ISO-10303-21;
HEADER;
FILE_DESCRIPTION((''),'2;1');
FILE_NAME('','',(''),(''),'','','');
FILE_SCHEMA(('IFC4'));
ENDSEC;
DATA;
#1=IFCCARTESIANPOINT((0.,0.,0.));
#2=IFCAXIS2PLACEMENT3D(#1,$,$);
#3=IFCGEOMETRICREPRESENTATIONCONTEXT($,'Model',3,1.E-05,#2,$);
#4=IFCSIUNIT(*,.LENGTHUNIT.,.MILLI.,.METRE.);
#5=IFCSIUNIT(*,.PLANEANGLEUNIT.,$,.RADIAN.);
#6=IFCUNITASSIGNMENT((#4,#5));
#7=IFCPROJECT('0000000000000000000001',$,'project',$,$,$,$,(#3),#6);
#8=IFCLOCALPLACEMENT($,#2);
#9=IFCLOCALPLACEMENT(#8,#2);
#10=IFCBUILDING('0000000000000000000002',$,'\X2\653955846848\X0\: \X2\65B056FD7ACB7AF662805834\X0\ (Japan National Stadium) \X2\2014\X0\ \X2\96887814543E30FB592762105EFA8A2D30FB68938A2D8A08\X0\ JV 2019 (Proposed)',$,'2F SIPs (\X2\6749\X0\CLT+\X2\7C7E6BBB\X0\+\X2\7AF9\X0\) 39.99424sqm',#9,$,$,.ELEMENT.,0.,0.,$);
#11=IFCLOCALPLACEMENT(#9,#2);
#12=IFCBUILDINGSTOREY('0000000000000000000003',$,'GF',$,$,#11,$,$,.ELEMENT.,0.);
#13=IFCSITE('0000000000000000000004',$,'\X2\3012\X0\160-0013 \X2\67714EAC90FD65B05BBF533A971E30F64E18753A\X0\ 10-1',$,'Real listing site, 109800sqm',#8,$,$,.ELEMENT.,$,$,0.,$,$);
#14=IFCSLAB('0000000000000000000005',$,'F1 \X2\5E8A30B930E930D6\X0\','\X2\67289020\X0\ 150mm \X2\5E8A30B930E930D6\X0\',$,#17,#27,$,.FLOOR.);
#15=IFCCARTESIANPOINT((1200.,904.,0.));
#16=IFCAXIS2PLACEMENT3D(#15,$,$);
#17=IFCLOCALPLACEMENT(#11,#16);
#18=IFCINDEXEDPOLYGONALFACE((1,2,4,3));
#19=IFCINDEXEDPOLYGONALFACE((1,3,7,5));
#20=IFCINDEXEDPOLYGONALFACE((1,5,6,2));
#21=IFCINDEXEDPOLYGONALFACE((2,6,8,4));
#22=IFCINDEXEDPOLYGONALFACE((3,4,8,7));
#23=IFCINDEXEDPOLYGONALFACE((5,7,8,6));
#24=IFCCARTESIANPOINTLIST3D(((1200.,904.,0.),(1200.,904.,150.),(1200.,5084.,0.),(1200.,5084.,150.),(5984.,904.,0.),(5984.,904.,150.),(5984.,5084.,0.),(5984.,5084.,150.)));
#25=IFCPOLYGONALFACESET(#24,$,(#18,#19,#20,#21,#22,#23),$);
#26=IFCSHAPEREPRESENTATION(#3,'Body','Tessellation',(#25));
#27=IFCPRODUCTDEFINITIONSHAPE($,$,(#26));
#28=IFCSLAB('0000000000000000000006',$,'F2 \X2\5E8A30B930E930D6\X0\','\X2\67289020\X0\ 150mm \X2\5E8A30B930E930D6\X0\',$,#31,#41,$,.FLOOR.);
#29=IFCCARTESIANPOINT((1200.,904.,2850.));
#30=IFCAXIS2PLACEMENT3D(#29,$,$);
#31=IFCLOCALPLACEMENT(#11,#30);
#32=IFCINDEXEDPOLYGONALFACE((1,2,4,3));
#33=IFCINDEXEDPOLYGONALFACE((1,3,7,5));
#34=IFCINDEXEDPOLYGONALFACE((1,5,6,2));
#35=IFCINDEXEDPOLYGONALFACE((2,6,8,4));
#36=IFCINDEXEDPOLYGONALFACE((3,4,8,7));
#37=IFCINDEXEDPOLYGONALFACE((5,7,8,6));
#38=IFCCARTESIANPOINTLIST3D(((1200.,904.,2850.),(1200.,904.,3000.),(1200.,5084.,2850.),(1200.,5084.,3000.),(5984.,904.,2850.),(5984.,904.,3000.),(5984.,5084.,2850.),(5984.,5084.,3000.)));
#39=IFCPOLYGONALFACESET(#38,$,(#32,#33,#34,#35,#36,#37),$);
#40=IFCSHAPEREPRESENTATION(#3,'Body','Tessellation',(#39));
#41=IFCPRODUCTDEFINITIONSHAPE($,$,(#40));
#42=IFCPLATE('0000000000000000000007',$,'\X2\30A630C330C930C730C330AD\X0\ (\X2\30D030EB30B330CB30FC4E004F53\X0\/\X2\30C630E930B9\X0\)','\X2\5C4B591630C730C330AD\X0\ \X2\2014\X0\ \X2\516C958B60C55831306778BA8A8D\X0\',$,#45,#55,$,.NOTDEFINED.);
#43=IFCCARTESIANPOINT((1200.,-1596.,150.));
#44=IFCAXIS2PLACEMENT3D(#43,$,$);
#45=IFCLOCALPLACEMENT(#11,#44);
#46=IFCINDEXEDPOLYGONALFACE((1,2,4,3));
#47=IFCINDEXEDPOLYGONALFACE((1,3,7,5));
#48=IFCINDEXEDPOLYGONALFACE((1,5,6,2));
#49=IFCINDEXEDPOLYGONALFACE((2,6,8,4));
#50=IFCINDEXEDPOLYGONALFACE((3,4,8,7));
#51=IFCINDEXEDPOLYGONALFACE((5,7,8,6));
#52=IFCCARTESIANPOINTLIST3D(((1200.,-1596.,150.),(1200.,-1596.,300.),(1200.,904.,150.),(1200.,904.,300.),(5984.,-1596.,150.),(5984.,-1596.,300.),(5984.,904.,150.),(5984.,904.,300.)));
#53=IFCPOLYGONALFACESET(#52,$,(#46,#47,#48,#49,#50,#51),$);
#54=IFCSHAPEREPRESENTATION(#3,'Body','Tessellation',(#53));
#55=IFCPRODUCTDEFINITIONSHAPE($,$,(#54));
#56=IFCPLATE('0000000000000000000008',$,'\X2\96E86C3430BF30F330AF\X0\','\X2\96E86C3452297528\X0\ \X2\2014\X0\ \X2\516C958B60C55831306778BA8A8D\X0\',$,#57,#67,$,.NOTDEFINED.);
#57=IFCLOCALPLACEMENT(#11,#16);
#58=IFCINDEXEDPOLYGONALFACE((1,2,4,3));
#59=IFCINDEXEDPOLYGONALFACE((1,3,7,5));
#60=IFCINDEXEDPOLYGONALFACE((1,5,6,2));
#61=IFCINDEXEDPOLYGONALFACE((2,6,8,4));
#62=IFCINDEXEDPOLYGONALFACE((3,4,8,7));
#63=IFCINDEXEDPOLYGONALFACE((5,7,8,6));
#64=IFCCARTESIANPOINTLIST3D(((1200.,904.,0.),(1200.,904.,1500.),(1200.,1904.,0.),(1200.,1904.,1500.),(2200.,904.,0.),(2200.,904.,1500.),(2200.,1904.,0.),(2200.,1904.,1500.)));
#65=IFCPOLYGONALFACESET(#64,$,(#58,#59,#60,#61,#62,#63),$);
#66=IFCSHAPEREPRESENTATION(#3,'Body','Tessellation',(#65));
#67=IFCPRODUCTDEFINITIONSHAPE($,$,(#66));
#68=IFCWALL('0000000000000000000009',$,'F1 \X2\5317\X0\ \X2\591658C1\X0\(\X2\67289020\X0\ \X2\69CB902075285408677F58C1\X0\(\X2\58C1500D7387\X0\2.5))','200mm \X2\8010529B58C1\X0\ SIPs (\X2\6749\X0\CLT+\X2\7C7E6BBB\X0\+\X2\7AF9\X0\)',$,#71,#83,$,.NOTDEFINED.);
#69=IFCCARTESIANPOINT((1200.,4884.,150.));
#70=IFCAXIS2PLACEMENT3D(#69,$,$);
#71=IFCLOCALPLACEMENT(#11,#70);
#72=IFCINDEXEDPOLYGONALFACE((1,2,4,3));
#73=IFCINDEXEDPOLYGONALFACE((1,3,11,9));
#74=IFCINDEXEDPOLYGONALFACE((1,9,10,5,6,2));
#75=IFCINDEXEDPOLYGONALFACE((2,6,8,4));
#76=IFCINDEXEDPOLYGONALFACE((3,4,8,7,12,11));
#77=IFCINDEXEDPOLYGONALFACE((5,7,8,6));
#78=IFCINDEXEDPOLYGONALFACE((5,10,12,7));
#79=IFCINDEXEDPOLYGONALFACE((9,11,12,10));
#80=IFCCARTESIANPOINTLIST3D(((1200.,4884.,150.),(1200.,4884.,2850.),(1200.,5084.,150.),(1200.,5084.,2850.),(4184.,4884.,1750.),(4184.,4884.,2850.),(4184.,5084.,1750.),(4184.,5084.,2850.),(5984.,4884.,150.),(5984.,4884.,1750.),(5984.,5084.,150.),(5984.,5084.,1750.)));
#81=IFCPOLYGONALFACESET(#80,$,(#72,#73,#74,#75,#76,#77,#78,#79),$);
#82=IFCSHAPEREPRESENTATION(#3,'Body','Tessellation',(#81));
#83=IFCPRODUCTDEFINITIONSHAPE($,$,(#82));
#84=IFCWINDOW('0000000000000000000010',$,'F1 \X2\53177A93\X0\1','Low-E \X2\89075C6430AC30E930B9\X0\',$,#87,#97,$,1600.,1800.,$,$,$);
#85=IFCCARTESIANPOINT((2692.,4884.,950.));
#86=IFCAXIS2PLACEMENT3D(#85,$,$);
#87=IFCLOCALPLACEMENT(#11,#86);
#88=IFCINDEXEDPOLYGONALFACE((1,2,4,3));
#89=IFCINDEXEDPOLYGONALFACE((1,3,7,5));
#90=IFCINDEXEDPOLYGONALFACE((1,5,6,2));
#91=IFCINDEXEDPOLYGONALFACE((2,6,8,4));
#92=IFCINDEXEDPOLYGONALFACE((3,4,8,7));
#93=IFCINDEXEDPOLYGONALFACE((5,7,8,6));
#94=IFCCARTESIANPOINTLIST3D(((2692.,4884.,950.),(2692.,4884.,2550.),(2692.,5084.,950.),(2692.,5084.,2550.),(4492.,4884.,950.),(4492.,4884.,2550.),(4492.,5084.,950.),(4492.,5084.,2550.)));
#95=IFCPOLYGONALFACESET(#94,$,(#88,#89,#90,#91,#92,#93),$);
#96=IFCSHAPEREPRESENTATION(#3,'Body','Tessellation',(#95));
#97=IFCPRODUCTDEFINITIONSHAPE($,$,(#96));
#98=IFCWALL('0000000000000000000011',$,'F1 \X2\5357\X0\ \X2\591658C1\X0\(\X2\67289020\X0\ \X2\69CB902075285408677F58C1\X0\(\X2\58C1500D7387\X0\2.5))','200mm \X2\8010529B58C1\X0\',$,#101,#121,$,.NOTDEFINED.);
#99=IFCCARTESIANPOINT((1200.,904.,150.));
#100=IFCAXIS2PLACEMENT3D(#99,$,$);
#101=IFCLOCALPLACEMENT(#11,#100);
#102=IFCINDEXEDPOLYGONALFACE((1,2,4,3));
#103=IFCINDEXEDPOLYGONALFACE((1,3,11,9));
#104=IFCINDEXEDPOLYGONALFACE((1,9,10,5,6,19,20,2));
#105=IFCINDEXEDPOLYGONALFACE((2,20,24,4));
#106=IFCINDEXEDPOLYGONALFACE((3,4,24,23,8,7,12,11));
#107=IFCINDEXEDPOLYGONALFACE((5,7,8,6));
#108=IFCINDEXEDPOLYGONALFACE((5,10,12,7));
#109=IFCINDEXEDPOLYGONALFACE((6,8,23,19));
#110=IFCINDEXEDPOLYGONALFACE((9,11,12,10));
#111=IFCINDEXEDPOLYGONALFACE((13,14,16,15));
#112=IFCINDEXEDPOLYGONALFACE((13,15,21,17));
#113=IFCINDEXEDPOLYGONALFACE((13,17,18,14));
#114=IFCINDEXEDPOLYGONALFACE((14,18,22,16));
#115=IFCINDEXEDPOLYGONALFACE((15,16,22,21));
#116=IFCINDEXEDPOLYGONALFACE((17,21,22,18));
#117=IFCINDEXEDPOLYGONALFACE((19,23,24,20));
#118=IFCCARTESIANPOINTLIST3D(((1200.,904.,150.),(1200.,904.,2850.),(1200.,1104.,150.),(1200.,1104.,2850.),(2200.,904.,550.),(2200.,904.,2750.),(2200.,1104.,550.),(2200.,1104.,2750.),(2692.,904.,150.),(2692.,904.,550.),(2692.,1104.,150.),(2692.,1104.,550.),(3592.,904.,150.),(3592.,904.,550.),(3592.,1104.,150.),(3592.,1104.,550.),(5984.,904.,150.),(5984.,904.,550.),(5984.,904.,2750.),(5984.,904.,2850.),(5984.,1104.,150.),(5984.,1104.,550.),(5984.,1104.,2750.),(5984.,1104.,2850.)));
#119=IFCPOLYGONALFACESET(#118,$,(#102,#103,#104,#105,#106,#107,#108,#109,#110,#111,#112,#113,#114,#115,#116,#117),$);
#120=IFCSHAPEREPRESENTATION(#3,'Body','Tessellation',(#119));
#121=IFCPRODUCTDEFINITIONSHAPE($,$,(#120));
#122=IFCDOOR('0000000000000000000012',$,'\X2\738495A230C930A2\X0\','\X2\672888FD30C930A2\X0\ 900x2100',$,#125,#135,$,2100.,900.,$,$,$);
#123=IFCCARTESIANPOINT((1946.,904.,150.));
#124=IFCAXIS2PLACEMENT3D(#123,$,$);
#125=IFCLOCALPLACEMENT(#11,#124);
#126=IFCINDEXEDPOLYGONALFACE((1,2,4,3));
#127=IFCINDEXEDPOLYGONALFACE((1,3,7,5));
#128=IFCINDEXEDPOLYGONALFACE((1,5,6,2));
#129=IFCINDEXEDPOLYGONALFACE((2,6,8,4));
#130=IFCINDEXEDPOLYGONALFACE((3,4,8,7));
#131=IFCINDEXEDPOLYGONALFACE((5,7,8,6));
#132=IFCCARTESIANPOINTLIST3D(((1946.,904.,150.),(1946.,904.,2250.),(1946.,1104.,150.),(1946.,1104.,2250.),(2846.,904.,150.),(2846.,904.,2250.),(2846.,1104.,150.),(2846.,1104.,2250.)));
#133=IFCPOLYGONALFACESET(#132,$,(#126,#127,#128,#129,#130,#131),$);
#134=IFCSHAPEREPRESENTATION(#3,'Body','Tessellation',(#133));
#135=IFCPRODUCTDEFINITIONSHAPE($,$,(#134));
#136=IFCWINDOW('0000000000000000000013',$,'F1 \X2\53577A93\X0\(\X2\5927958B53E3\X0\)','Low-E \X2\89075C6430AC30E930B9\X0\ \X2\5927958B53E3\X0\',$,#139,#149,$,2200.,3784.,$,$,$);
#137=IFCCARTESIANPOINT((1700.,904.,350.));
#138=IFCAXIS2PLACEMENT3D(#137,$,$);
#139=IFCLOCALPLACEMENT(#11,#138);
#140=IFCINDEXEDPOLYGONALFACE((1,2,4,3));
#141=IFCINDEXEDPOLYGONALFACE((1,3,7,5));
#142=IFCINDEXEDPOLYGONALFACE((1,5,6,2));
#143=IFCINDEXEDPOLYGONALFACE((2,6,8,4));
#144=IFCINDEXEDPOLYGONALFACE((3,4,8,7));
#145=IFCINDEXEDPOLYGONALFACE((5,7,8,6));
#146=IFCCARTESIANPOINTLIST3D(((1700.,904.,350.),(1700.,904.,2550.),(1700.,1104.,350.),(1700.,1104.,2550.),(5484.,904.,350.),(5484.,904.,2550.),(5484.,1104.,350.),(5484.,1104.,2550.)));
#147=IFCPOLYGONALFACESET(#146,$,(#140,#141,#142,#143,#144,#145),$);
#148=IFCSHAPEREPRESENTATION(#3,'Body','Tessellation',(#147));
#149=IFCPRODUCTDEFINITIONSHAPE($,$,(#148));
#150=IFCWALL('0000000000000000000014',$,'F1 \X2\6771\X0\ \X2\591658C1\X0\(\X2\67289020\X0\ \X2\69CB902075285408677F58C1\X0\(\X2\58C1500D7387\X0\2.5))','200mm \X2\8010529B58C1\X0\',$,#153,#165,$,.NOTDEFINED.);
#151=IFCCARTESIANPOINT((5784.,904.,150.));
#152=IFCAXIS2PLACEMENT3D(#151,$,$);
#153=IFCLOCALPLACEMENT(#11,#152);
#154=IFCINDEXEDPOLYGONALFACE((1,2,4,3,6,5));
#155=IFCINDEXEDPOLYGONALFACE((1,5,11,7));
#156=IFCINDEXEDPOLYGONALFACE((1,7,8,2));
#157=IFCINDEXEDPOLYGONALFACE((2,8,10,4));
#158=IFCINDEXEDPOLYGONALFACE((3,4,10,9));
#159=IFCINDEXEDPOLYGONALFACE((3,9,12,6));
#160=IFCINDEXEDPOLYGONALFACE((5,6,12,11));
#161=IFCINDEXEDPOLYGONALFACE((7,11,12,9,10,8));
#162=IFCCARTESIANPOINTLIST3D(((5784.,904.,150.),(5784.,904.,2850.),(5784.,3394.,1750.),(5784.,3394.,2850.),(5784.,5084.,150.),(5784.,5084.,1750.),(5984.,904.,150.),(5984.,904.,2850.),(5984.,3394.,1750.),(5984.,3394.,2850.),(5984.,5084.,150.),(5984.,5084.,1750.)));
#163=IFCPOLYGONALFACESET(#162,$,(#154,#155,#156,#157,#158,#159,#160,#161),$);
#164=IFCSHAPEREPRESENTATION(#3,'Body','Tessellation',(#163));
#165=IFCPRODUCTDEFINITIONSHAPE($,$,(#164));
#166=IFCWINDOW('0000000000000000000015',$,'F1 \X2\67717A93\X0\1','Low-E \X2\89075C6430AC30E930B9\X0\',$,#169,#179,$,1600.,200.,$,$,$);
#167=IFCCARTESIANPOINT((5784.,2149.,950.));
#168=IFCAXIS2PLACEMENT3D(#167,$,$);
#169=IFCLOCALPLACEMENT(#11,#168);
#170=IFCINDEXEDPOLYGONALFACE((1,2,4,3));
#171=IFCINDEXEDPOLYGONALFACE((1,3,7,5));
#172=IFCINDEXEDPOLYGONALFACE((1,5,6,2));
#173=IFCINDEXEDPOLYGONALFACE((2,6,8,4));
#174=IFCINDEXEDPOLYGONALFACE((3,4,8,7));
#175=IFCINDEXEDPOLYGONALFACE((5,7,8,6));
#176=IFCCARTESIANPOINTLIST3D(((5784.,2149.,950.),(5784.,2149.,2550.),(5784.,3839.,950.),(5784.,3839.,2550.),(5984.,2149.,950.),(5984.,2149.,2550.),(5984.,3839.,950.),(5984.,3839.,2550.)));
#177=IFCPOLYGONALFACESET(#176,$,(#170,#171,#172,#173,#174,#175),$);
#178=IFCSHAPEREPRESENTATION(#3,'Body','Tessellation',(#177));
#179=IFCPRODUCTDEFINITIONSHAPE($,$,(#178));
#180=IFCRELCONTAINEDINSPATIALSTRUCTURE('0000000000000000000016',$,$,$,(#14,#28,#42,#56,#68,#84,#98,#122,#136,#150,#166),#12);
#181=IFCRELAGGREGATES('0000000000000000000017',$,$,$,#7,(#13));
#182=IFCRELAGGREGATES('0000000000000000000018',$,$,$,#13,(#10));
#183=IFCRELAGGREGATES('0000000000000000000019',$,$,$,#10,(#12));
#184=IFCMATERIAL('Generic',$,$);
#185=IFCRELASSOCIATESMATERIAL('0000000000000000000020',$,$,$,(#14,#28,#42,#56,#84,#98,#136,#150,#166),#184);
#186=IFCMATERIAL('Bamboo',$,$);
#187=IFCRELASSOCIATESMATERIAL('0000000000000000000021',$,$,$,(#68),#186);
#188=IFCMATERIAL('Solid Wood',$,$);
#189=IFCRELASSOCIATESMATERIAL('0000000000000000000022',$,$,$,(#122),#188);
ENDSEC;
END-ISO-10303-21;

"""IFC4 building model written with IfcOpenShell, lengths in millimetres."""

from ifc_helpers import new_model, si_unit, frame, frame_2d, origin, place, context, project, spatial, rectangle, extrude, material, element, fill, save


model = new_model("IFC4")

# Units and contexts
model_context = context("Model", 3, precision=1e-05, world=origin())
ifc_project = project(units=[si_unit("LENGTHUNIT", "METRE", prefix="MILLI"), si_unit("PLANEANGLEUNIT", "RADIAN")], contexts=[model_context])

# Site, building, storey
site_placement = place(None, origin())
site = spatial("IfcSite", under=ifc_project, at=site_placement, Name="〒160-0013 東京都新宿区霞ヶ丘町 10-1", ObjectType="Real listing site, 109800sqm", CompositionType="ELEMENT", RefElevation=0.0)
building_placement = place(site_placement, origin())
building = spatial("IfcBuilding", under=site, at=building_placement, Name="改善案: 新国立競技場 (Japan National Stadium) — 隈研吾・大成建設・梓設計 JV 2019 (Proposed)", ObjectType="2F SIPs (杉CLT+籾殻+竹) 39.99424sqm", CompositionType="ELEMENT", ElevationOfRefHeight=0.0, ElevationOfTerrain=0.0)
storey_placement = place(building_placement, origin())
storey = spatial("IfcBuildingStorey", under=building, at=storey_placement, Name="GF", CompositionType="ELEMENT", Elevation=0.0)

# Slabs
ifc_material_1 = material(Name="Generic")
slab_1_placement = place(storey_placement, frame((1200.0, 904.0, 0.0)))
element("IfcSlab", 1, at=slab_1_placement, inside=storey, material=ifc_material_1, Name="F1 床スラブ", Description="木造 150mm 床スラブ", PredefinedType="FLOOR", context=model_context, shape_type="SweptSolid", body=[
    extrude(rectangle(XDim=4784.0, YDim=4180.0, at=frame_2d((2392.0, 2090.0))), frame((1200.0, 904.0, 0.0)), (0.0, 0.0, 1.0), 150.0),
])
slab_2_placement = place(storey_placement, frame((1200.0, 904.0, 2850.0)))
element("IfcSlab", 2, at=slab_2_placement, inside=storey, material=ifc_material_1, Name="F2 床スラブ", Description="木造 150mm 床スラブ", PredefinedType="FLOOR", context=model_context, shape_type="SweptSolid", body=[
    extrude(rectangle(XDim=4784.0, YDim=4180.0, at=frame_2d((2392.0, 2090.0))), frame((1200.0, 904.0, 2850.0)), (0.0, 0.0, 1.0), 150.0),
])

# Plates
plate_1_placement = place(storey_placement, frame((1200.0, -1596.0, 150.0)))
element("IfcPlate", 3, at=plate_1_placement, inside=storey, material=ifc_material_1, Name="ウッドデッキ (バルコニー一体/テラス)", Description="屋外デッキ — 公開情報で確認", PredefinedType="NOTDEFINED", context=model_context, shape_type="SweptSolid", body=[
    extrude(rectangle(XDim=4784.0, YDim=2500.0, at=frame_2d((2392.0, 1250.0))), frame((1200.0, -1596.0, 150.0)), (0.0, 0.0, 1.0), 150.0),
])
plate_2_placement = place(storey_placement, frame((1200.0, 904.0, 0.0)))
element("IfcPlate", 4, at=plate_2_placement, inside=storey, material=ifc_material_1, Name="雨水タンク", Description="雨水利用 — 公開情報で確認", PredefinedType="NOTDEFINED", context=model_context, shape_type="SweptSolid", body=[
    extrude(rectangle(XDim=1000.0, YDim=1000.0, at=frame_2d((500.0, 500.0))), frame((1200.0, 904.0, 0.0)), (0.0, 0.0, 1.0), 1500.0),
])

# Wall, opening, window
ifc_material_2 = material(Name="Bamboo")
wall_1_placement = place(storey_placement, frame((1200.0, 4884.0, 150.0)))
wall_1 = element("IfcWall", 5, at=wall_1_placement, inside=storey, material=ifc_material_2, Name="F1 北 外壁(木造 構造用合板壁(壁倍率2.5))", Description="200mm 耐力壁 SIPs (杉CLT+籾殻+竹)", PredefinedType="NOTDEFINED", context=model_context, shape_type="SweptSolid", body=[
    extrude(rectangle(XDim=4784.0, YDim=200.0, at=frame_2d((2392.0, 100.0))), frame((1200.0, 4884.0, 150.0)), (0.0, 0.0, 1.0), 2700.0),
])
opening_1_placement = place(storey_placement, frame((2692.0, 4884.0, 950.0)))
opening_1 = element("IfcOpeningElement", 6, at=opening_1_placement, cuts=wall_1, PredefinedType="NOTDEFINED", context=model_context, shape_type="SweptSolid", body=[
    extrude(rectangle(XDim=1800.0, YDim=200.0, at=frame_2d((900.0, 100.0))), frame((2692.0, 4884.0, 950.0)), (0.0, 0.0, 1.0), 1600.0),
])
window_1_placement = place(storey_placement, frame((2692.0, 4884.0, 950.0)))
window_1 = element("IfcWindow", 7, at=window_1_placement, inside=storey, material=ifc_material_1, Name="F1 北窓1", Description="Low-E 複層ガラス", OverallHeight=1600.0, OverallWidth=1800.0, context=model_context, shape_type="SweptSolid", body=[
    extrude(rectangle(XDim=1800.0, YDim=200.0, at=frame_2d((900.0, 100.0))), frame((2692.0, 4884.0, 950.0)), (0.0, 0.0, 1.0), 1600.0),
])
fill(opening_1, window_1)

# Wall, openings, door, window
wall_2_placement = place(storey_placement, frame((1200.0, 904.0, 150.0)))
wall_2 = element("IfcWall", 8, at=wall_2_placement, inside=storey, material=ifc_material_1, Name="F1 南 外壁(木造 構造用合板壁(壁倍率2.5))", Description="200mm 耐力壁", PredefinedType="NOTDEFINED", context=model_context, shape_type="SweptSolid", body=[
    extrude(rectangle(XDim=4784.0, YDim=200.0, at=frame_2d((2392.0, 100.0))), frame((1200.0, 904.0, 150.0)), (0.0, 0.0, 1.0), 2700.0),
])
opening_2_placement = place(storey_placement, frame((1946.0, 904.0, 150.0)))
opening_2 = element("IfcOpeningElement", 9, at=opening_2_placement, cuts=wall_2, PredefinedType="NOTDEFINED", context=model_context, shape_type="SweptSolid", body=[
    extrude(rectangle(XDim=900.0, YDim=200.0, at=frame_2d((450.0, 100.0))), frame((1946.0, 904.0, 150.0)), (0.0, 0.0, 1.0), 2100.0),
])
opening_3_placement = place(storey_placement, frame((1700.0, 904.0, 350.0)))
opening_3 = element("IfcOpeningElement", 10, at=opening_3_placement, cuts=wall_2, PredefinedType="NOTDEFINED", context=model_context, shape_type="SweptSolid", body=[
    extrude(rectangle(XDim=3784.0, YDim=200.0, at=frame_2d((1892.0, 100.0))), frame((1700.0, 904.0, 350.0)), (0.0, 0.0, 1.0), 2200.0),
])
ifc_material_3 = material(Name="Solid Wood")
door_placement = place(storey_placement, frame((1946.0, 904.0, 150.0)))
door = element("IfcDoor", 11, at=door_placement, inside=storey, material=ifc_material_3, Name="玄関ドア", Description="木製ドア 900x2100", OverallHeight=2100.0, OverallWidth=900.0, context=model_context, shape_type="SweptSolid", body=[
    extrude(rectangle(XDim=900.0, YDim=200.0, at=frame_2d((450.0, 100.0))), frame((1946.0, 904.0, 150.0)), (0.0, 0.0, 1.0), 2100.0),
])
fill(opening_2, door)
window_2_placement = place(storey_placement, frame((1700.0, 904.0, 350.0)))
window_2 = element("IfcWindow", 12, at=window_2_placement, inside=storey, material=ifc_material_1, Name="F1 南窓(大開口)", Description="Low-E 複層ガラス 大開口", OverallHeight=2200.0, OverallWidth=3784.0, context=model_context, shape_type="SweptSolid", body=[
    extrude(rectangle(XDim=3784.0, YDim=200.0, at=frame_2d((1892.0, 100.0))), frame((1700.0, 904.0, 350.0)), (0.0, 0.0, 1.0), 2200.0),
])
fill(opening_3, window_2)

# Wall, opening, window
wall_3_placement = place(storey_placement, frame((5784.0, 904.0, 150.0)))
wall_3 = element("IfcWall", 13, at=wall_3_placement, inside=storey, material=ifc_material_1, Name="F1 東 外壁(木造 構造用合板壁(壁倍率2.5))", Description="200mm 耐力壁", PredefinedType="NOTDEFINED", context=model_context, shape_type="SweptSolid", body=[
    extrude(rectangle(XDim=200.0, YDim=4180.0, at=frame_2d((100.0, 2090.0))), frame((5784.0, 904.0, 150.0)), (0.0, 0.0, 1.0), 2700.0),
])
opening_4_placement = place(storey_placement, frame((5784.0, 2149.0, 950.0)))
opening_4 = element("IfcOpeningElement", 14, at=opening_4_placement, cuts=wall_3, PredefinedType="NOTDEFINED", context=model_context, shape_type="SweptSolid", body=[
    extrude(rectangle(XDim=200.0, YDim=1690.0, at=frame_2d((100.0, 845.0))), frame((5784.0, 2149.0, 950.0)), (0.0, 0.0, 1.0), 1600.0),
])
window_3_placement = place(storey_placement, frame((5784.0, 2149.0, 950.0)))
window_3 = element("IfcWindow", 15, at=window_3_placement, inside=storey, material=ifc_material_1, Name="F1 東窓1", Description="Low-E 複層ガラス", OverallHeight=1600.0, OverallWidth=200.0, context=model_context, shape_type="SweptSolid", body=[
    extrude(rectangle(XDim=200.0, YDim=1690.0, at=frame_2d((100.0, 845.0))), frame((5784.0, 2149.0, 950.0)), (0.0, 0.0, 1.0), 1600.0),
])
fill(opening_4, window_3)

save(model, "model.ifc")
